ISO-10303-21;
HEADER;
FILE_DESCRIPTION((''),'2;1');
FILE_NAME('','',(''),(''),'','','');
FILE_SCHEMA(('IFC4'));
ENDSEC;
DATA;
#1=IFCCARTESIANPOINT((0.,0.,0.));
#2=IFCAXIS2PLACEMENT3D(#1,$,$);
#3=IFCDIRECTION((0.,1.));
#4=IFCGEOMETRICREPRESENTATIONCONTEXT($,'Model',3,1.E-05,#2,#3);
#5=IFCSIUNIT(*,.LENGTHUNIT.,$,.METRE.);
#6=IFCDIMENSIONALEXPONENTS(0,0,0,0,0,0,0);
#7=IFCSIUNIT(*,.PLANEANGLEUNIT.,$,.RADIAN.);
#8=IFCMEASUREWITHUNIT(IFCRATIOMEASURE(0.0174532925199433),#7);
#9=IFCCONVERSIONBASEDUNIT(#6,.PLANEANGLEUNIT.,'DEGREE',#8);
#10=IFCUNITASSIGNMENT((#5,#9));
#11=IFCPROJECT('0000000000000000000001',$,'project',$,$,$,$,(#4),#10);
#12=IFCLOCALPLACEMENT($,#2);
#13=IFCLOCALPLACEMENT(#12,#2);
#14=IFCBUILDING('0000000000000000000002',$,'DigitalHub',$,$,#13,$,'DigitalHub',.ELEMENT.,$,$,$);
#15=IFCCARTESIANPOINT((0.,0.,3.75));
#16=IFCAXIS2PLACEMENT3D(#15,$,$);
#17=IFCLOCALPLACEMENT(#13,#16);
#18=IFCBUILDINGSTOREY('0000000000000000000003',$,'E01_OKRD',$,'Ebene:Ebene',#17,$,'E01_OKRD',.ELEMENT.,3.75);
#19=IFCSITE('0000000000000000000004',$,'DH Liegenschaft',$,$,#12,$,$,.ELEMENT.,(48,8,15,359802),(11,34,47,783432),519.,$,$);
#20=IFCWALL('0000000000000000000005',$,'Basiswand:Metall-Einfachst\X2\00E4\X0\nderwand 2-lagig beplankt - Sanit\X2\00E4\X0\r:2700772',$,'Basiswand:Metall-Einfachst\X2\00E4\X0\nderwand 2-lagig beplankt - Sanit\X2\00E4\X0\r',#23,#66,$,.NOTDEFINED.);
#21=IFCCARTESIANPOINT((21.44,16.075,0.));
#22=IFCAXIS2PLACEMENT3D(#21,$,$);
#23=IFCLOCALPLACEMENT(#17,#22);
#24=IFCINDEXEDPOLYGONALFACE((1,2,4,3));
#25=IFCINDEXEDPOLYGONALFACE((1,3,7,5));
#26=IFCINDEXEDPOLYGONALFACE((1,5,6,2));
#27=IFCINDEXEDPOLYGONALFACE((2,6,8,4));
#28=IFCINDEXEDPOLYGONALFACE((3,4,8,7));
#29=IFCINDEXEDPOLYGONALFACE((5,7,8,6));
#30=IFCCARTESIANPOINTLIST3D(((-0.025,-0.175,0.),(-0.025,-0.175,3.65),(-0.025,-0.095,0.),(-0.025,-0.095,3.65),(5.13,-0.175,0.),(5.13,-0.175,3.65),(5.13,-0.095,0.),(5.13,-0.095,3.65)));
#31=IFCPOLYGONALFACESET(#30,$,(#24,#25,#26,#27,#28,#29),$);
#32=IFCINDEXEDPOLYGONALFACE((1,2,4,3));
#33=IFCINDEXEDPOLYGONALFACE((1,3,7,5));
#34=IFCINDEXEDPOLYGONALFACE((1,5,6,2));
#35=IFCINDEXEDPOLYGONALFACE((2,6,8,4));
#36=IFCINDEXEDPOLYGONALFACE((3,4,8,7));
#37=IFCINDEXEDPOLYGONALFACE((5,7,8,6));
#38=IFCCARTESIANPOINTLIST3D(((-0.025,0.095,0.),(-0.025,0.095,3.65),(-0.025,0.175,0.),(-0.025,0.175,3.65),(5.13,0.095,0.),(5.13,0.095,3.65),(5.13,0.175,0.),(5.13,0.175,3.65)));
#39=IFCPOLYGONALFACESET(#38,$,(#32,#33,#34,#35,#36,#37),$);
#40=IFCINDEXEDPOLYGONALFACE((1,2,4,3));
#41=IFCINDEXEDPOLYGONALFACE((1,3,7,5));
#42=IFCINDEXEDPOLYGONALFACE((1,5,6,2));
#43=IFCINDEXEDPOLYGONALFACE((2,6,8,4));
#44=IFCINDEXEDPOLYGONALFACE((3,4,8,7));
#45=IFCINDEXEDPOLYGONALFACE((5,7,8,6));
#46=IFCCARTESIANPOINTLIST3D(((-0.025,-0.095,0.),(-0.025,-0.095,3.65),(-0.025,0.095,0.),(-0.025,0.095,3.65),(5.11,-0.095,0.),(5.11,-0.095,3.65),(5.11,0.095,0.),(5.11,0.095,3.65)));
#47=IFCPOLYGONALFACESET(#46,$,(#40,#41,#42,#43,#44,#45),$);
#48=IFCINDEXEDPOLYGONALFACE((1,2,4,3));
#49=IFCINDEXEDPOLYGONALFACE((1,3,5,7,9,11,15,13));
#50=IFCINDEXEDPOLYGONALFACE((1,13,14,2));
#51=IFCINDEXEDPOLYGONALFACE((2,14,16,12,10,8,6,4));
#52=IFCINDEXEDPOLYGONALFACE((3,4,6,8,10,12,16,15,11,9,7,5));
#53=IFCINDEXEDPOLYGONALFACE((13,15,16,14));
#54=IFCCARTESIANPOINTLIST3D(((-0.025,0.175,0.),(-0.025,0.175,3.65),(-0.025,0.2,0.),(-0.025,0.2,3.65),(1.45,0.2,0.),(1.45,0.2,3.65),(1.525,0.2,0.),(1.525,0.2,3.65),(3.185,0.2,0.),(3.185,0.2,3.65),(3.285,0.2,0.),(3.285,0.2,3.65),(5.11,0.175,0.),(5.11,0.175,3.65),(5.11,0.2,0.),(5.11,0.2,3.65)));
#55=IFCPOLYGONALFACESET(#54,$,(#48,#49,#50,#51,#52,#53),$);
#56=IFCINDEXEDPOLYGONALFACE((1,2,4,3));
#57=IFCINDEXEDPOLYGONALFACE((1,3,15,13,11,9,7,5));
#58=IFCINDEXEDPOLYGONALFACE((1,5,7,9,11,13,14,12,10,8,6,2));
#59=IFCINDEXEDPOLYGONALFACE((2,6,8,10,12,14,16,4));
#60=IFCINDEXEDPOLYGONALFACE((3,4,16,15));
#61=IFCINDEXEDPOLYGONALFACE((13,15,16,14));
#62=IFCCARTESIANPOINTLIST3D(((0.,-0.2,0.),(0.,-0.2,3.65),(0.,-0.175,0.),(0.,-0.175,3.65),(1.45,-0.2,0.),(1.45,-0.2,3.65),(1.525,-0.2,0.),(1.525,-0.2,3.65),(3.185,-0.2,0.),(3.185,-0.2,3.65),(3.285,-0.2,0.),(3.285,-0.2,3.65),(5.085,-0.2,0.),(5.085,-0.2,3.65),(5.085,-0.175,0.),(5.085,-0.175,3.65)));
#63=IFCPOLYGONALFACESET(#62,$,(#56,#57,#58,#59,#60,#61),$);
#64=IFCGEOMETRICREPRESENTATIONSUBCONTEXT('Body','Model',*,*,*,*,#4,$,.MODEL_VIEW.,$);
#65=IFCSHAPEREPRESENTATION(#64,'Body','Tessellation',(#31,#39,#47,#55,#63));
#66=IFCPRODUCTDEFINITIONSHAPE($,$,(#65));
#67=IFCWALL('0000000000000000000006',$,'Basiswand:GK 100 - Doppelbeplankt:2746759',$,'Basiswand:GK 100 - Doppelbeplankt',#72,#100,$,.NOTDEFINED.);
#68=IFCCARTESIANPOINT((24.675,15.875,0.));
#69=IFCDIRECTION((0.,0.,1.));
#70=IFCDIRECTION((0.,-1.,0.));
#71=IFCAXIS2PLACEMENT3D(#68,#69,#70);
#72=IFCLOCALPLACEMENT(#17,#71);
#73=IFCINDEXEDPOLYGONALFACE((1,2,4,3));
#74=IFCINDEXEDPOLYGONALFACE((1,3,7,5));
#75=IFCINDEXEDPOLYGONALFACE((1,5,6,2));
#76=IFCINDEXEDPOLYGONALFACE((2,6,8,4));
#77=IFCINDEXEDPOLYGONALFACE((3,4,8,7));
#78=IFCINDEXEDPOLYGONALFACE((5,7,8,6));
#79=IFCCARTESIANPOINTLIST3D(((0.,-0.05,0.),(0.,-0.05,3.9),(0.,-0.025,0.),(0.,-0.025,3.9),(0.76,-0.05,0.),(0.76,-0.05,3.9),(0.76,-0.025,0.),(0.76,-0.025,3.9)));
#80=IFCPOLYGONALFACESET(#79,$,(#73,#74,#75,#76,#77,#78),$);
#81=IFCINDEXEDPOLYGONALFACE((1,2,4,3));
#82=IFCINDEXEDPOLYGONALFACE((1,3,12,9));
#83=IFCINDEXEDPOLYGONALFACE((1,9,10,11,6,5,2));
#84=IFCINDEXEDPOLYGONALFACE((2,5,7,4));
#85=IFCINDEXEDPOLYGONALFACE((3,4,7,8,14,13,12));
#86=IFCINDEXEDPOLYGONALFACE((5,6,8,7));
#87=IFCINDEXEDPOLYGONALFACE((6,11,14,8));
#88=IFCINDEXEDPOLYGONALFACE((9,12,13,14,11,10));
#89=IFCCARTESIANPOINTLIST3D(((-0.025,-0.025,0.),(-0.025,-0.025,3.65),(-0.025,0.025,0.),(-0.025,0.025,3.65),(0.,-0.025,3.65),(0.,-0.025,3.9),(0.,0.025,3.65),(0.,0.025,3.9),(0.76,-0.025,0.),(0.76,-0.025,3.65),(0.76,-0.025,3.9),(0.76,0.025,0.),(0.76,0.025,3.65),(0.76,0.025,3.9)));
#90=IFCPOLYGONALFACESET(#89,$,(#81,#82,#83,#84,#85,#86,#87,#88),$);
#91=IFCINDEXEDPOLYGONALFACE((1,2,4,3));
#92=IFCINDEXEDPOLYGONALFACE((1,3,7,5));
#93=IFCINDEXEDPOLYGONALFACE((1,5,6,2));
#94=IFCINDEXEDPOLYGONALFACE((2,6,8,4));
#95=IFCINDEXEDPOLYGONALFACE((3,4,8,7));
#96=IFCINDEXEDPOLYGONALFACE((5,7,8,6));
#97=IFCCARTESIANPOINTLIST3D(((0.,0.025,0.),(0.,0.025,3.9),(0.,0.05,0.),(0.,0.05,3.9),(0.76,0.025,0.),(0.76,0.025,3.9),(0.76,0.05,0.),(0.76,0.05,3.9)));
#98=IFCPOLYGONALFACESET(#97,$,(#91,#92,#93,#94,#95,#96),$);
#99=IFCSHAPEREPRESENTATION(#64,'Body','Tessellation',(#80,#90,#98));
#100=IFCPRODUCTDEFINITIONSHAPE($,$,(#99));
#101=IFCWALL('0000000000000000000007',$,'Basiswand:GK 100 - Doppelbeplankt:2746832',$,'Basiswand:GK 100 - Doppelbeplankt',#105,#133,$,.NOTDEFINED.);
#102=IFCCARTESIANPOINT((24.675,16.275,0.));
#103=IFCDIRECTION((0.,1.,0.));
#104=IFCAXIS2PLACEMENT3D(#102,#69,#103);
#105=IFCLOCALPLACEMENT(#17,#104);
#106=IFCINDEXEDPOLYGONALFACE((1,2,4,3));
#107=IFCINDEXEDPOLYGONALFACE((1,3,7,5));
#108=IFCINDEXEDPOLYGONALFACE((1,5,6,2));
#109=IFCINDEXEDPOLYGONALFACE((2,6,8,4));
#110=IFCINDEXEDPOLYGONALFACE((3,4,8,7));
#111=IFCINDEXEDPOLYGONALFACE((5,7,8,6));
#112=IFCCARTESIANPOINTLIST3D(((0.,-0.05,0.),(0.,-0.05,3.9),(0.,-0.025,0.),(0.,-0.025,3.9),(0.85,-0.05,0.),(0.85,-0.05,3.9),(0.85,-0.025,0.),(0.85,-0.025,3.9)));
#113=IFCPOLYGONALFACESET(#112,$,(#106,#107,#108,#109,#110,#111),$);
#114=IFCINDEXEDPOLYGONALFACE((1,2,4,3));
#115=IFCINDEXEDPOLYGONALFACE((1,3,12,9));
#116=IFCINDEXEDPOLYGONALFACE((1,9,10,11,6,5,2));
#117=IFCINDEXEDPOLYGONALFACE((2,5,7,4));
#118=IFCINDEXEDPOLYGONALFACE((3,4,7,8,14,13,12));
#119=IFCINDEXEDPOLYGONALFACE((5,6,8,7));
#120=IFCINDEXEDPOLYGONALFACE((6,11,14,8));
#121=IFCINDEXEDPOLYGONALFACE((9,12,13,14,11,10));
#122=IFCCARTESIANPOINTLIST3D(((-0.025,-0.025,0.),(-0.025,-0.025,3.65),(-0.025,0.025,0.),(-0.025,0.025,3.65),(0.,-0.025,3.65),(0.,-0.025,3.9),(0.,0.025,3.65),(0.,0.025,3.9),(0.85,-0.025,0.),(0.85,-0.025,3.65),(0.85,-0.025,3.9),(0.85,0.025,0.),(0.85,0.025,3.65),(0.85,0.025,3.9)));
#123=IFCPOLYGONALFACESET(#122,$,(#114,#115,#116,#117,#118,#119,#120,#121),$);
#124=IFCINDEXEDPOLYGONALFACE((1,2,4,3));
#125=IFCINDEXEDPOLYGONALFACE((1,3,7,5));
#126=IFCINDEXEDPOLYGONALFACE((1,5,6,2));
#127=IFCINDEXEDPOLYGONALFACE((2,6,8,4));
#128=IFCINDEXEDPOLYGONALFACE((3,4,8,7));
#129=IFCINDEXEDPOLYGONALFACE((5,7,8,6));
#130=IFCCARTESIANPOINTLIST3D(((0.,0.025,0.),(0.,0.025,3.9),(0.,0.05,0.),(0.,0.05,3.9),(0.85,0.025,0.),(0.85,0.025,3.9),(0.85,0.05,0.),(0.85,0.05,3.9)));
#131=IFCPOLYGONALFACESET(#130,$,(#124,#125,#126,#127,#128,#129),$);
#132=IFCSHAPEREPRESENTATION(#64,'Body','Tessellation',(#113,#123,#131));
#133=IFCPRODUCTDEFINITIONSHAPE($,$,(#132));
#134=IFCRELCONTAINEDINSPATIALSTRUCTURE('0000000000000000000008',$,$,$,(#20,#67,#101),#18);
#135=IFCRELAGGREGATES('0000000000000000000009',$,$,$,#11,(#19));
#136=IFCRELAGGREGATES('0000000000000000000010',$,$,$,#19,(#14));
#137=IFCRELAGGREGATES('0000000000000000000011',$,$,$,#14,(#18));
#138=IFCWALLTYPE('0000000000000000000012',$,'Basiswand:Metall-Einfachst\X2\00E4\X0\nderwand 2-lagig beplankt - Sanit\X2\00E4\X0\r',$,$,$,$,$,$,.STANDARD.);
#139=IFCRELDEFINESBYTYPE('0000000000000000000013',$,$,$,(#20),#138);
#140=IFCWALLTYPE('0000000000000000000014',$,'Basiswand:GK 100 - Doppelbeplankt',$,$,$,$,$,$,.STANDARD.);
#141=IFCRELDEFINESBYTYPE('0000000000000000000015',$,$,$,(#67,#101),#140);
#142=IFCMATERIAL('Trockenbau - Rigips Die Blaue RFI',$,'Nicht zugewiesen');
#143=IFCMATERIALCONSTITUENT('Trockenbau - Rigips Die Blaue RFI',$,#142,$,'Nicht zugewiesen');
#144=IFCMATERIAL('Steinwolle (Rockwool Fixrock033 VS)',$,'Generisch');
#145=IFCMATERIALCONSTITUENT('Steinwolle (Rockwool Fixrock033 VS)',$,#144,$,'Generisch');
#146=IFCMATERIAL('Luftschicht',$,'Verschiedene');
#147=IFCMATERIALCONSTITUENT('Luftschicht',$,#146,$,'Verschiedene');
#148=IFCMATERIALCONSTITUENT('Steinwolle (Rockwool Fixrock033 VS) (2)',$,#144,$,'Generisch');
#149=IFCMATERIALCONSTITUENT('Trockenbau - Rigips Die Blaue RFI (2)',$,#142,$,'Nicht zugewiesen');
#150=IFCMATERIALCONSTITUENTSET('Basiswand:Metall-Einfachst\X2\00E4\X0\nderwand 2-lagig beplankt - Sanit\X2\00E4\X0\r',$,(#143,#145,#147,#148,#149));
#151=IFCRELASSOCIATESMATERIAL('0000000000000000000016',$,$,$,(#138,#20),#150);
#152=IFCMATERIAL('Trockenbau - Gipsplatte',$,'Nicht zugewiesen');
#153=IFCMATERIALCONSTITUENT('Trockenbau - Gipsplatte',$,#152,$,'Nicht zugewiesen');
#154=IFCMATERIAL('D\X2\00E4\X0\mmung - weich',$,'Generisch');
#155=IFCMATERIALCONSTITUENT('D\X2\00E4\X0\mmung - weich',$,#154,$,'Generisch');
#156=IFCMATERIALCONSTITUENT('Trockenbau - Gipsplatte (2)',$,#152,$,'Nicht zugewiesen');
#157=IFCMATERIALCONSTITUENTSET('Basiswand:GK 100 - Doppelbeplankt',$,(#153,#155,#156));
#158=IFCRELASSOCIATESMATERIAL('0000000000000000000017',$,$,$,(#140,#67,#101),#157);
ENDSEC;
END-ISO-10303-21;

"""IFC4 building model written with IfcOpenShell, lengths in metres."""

from ifc_helpers import new_model, entity, si_unit, converted_unit, direction, frame, origin, place, context, subcontext, project, spatial, indexed_curve, outline, extrude, material, constituent, constituent_set, type_object, element, save


model = new_model("IFC4")

# Units and contexts
model_context = context("Model", 3, precision=1e-05, world=origin(), true_north=direction((0.0, 1.0)))
body_context = subcontext(model_context, "Body", "Model", "MODEL_VIEW")
ifc_project = project(units=[si_unit("LENGTHUNIT", "METRE"), converted_unit("PLANEANGLEUNIT", "DEGREE", entity("IfcRatioMeasure", 0.0174532925199433), si_unit("PLANEANGLEUNIT", "RADIAN"), dimensions=[0, 0, 0, 0, 0, 0, 0])], contexts=[model_context])

# Site, building, storey
site_placement = place(None, frame((0.0, 0.0, 0.0)))
site = spatial("IfcSite", under=ifc_project, at=site_placement, Name="DH Liegenschaft", CompositionType="ELEMENT", RefLatitude=(48, 8, 15, 359802), RefLongitude=(11, 34, 47, 783432), RefElevation=519.0)
building_placement = place(site_placement, origin())
building = spatial("IfcBuilding", under=site, at=building_placement, Name="DigitalHub", LongName="DigitalHub", CompositionType="ELEMENT")
storey_placement = place(building_placement, frame((0.0, 0.0, 3.75)))
storey = spatial("IfcBuildingStorey", under=building, at=storey_placement, Name="E01_OKRD", ObjectType="Ebene:Ebene", LongName="E01_OKRD", CompositionType="ELEMENT", Elevation=3.75)

# Shared definitions
ifc_material_1 = material(Name="Trockenbau - Rigips Die Blaue RFI", Category="Nicht zugewiesen")

# Walls
ifc_constituent_1 = constituent(ifc_material_1, Name="Trockenbau - Rigips Die Blaue RFI", Category="Nicht zugewiesen")
ifc_material_2 = material(Name="Steinwolle (Rockwool Fixrock033 VS)", Category="Generisch")
ifc_constituent_2 = constituent(ifc_material_2, Name="Steinwolle (Rockwool Fixrock033 VS)", Category="Generisch")
ifc_material_3 = material(Name="Luftschicht", Category="Verschiedene")
ifc_constituent_3 = constituent(ifc_material_3, Name="Luftschicht", Category="Verschiedene")
ifc_constituent_4 = constituent(ifc_material_2, Name="Steinwolle (Rockwool Fixrock033 VS) (2)", Category="Generisch")
ifc_constituent_5 = constituent(ifc_material_1, Name="Trockenbau - Rigips Die Blaue RFI (2)", Category="Nicht zugewiesen")
ifc_constituent_set_1 = constituent_set(constituents=[ifc_constituent_1, ifc_constituent_2, ifc_constituent_3, ifc_constituent_4, ifc_constituent_5], Name="Basiswand:Metall-Einfachständerwand 2-lagig beplankt - Sanitär")
wall_type_1 = type_object("IfcWallType", Name="Basiswand:Metall-Einfachständerwand 2-lagig beplankt - Sanitär", PredefinedType="STANDARD", material=ifc_constituent_set_1)
wall_1_placement = place(storey_placement, frame((21.44, 16.075, 0.0)))
element("IfcWall", 1, at=wall_1_placement, inside=storey, type_object=wall_type_1, material=ifc_constituent_set_1, Name="Basiswand:Metall-Einfachständerwand 2-lagig beplankt - Sanitär:2700772", ObjectType="Basiswand:Metall-Einfachständerwand 2-lagig beplankt - Sanitär", PredefinedType="NOTDEFINED", context=body_context, shape_type="SweptSolid", body=[
    extrude(outline(indexed_curve([(-2.5775, -0.04), (2.5775, -0.04), (2.5775, 0.04), (-2.5775, 0.04), (-2.5775, -0.04)], self_intersect=False)), frame((2.5525, -0.135, 0.0)), (0.0, 0.0, 1.0), 3.65),
    extrude(outline(indexed_curve([(-2.5775, -0.04), (2.5775, -0.04), (2.5775, 0.04), (-2.5775, 0.04), (-2.5775, -0.04)], self_intersect=False)), frame((2.5525, 0.135, 0.0)), (0.0, 0.0, 1.0), 3.65),
    extrude(outline(indexed_curve([(-2.5675, -0.095), (2.5675, -0.095), (2.5675, 0.095), (-2.5675, 0.095), (-2.5675, -0.095)], self_intersect=False)), frame((2.5425, 0.0, 0.0)), (0.0, 0.0, 1.0), 3.65),
    extrude(outline(indexed_curve([(-0.8331, -0.0062), (-0.7331, -0.0062), (0.9269, -0.0063), (1.0019, -0.0063), (2.4769, -0.0063), (2.4769, 0.0187), (-2.6581, 0.0188), (-2.6581, -0.0062), (-0.8331, -0.0062)], self_intersect=False)), frame((2.4519, 0.1937, 0.0), z_axis=(0.0, 0.0, 1.0), x_axis=(-1.0, 0.0, 0.0)), (0.0, 0.0, 1.0), 3.65),
    extrude(outline(indexed_curve([(-1.0019, -0.0062), (-0.9269, -0.0062), (0.7331, -0.0063), (0.8331, -0.0063), (2.6331, -0.0063), (2.6331, 0.0187), (-2.4519, 0.0188), (-2.4519, -0.0062), (-1.0019, -0.0062)], self_intersect=False)), frame((2.4519, -0.1938, 0.0)), (0.0, 0.0, 1.0), 3.65),
])
ifc_material_4 = material(Name="Trockenbau - Gipsplatte", Category="Nicht zugewiesen")
ifc_material_5 = material(Name="Dämmung - weich", Category="Generisch")
ifc_constituent_6 = constituent(ifc_material_4, Name="Trockenbau - Gipsplatte", Category="Nicht zugewiesen")
ifc_constituent_7 = constituent(ifc_material_5, Name="Dämmung - weich", Category="Generisch")
ifc_constituent_8 = constituent(ifc_material_4, Name="Trockenbau - Gipsplatte (2)", Category="Nicht zugewiesen")
ifc_constituent_set_2 = constituent_set(constituents=[ifc_constituent_6, ifc_constituent_7, ifc_constituent_8], Name="Basiswand:GK 100 - Doppelbeplankt")
wall_type_2 = type_object("IfcWallType", Name="Basiswand:GK 100 - Doppelbeplankt", PredefinedType="STANDARD", material=ifc_constituent_set_2)
wall_2_placement = place(storey_placement, frame((24.675, 15.875, 0.0), z_axis=(0.0, 0.0, 1.0), x_axis=(0.0, -1.0, 0.0)))
element("IfcWall", 2, at=wall_2_placement, inside=storey, type_object=wall_type_2, material=ifc_constituent_set_2, Name="Basiswand:GK 100 - Doppelbeplankt:2746759", ObjectType="Basiswand:GK 100 - Doppelbeplankt", PredefinedType="NOTDEFINED", context=body_context, shape_type="SweptSolid", body=[
    extrude(outline(indexed_curve([(-0.0125, -0.38), (0.0125, -0.38), (0.0125, 0.38), (-0.0125, 0.38), (-0.0125, -0.38)], self_intersect=False)), frame((0.38, -0.0375, 0.0), z_axis=(0.0, 0.0, 1.0), x_axis=(0.0, 1.0, 0.0)), (0.0, 0.0, 1.0), 3.9),
    extrude(outline(indexed_curve([(-2.6786, -0.3436), (0.9714, -0.3436), (0.9714, -0.3186), (1.2214, -0.3186), (1.2214, 0.4414), (0.9714, 0.4414), (-2.6786, 0.4414), (-2.6786, -0.3436)], self_intersect=False)), frame((0.3186, -0.025, 2.6786), z_axis=(0.0, 1.0, 0.0), x_axis=(0.0, 0.0, 1.0)), (0.0, 0.0, 1.0), 0.05),
    extrude(outline(indexed_curve([(-0.0125, -0.38), (0.0125, -0.38), (0.0125, 0.38), (-0.0125, 0.38), (-0.0125, -0.38)], self_intersect=False)), frame((0.38, 0.0375, 0.0), z_axis=(0.0, 0.0, 1.0), x_axis=(0.0, 1.0, 0.0)), (0.0, 0.0, 1.0), 3.9),
])
wall_3_placement = place(storey_placement, frame((24.675, 16.275, 0.0), z_axis=(0.0, 0.0, 1.0), x_axis=(0.0, 1.0, 0.0)))
element("IfcWall", 3, at=wall_3_placement, inside=storey, type_object=wall_type_2, material=ifc_constituent_set_2, Name="Basiswand:GK 100 - Doppelbeplankt:2746832", ObjectType="Basiswand:GK 100 - Doppelbeplankt", PredefinedType="NOTDEFINED", context=body_context, shape_type="SweptSolid", body=[
    extrude(outline(indexed_curve([(-0.0125, -0.425), (0.0125, -0.425), (0.0125, 0.425), (-0.0125, 0.425), (-0.0125, -0.425)], self_intersect=False)), frame((0.425, -0.0375, 0.0), z_axis=(0.0, 0.0, 1.0), x_axis=(0.0, 1.0, 0.0)), (0.0, 0.0, 1.0), 3.9),
    extrude(outline(indexed_curve([(-2.6786, -0.4929), (0.9714, -0.4929), (1.2214, -0.4929), (1.2214, 0.3571), (0.9714, 0.3571), (0.9714, 0.3821), (-2.6786, 0.3821), (-2.6786, -0.4929)], self_intersect=False)), frame((0.3571, 0.025, 2.6786), z_axis=(0.0, -1.0, 0.0), x_axis=(0.0, 0.0, 1.0)), (0.0, 0.0, 1.0), 0.05),
    extrude(outline(indexed_curve([(-0.0125, -0.425), (0.0125, -0.425), (0.0125, 0.425), (-0.0125, 0.425), (-0.0125, -0.425)], self_intersect=False)), frame((0.425, 0.0375, 0.0), z_axis=(0.0, 0.0, 1.0), x_axis=(0.0, 1.0, 0.0)), (0.0, 0.0, 1.0), 3.9),
])

save(model, "model.ifc")
